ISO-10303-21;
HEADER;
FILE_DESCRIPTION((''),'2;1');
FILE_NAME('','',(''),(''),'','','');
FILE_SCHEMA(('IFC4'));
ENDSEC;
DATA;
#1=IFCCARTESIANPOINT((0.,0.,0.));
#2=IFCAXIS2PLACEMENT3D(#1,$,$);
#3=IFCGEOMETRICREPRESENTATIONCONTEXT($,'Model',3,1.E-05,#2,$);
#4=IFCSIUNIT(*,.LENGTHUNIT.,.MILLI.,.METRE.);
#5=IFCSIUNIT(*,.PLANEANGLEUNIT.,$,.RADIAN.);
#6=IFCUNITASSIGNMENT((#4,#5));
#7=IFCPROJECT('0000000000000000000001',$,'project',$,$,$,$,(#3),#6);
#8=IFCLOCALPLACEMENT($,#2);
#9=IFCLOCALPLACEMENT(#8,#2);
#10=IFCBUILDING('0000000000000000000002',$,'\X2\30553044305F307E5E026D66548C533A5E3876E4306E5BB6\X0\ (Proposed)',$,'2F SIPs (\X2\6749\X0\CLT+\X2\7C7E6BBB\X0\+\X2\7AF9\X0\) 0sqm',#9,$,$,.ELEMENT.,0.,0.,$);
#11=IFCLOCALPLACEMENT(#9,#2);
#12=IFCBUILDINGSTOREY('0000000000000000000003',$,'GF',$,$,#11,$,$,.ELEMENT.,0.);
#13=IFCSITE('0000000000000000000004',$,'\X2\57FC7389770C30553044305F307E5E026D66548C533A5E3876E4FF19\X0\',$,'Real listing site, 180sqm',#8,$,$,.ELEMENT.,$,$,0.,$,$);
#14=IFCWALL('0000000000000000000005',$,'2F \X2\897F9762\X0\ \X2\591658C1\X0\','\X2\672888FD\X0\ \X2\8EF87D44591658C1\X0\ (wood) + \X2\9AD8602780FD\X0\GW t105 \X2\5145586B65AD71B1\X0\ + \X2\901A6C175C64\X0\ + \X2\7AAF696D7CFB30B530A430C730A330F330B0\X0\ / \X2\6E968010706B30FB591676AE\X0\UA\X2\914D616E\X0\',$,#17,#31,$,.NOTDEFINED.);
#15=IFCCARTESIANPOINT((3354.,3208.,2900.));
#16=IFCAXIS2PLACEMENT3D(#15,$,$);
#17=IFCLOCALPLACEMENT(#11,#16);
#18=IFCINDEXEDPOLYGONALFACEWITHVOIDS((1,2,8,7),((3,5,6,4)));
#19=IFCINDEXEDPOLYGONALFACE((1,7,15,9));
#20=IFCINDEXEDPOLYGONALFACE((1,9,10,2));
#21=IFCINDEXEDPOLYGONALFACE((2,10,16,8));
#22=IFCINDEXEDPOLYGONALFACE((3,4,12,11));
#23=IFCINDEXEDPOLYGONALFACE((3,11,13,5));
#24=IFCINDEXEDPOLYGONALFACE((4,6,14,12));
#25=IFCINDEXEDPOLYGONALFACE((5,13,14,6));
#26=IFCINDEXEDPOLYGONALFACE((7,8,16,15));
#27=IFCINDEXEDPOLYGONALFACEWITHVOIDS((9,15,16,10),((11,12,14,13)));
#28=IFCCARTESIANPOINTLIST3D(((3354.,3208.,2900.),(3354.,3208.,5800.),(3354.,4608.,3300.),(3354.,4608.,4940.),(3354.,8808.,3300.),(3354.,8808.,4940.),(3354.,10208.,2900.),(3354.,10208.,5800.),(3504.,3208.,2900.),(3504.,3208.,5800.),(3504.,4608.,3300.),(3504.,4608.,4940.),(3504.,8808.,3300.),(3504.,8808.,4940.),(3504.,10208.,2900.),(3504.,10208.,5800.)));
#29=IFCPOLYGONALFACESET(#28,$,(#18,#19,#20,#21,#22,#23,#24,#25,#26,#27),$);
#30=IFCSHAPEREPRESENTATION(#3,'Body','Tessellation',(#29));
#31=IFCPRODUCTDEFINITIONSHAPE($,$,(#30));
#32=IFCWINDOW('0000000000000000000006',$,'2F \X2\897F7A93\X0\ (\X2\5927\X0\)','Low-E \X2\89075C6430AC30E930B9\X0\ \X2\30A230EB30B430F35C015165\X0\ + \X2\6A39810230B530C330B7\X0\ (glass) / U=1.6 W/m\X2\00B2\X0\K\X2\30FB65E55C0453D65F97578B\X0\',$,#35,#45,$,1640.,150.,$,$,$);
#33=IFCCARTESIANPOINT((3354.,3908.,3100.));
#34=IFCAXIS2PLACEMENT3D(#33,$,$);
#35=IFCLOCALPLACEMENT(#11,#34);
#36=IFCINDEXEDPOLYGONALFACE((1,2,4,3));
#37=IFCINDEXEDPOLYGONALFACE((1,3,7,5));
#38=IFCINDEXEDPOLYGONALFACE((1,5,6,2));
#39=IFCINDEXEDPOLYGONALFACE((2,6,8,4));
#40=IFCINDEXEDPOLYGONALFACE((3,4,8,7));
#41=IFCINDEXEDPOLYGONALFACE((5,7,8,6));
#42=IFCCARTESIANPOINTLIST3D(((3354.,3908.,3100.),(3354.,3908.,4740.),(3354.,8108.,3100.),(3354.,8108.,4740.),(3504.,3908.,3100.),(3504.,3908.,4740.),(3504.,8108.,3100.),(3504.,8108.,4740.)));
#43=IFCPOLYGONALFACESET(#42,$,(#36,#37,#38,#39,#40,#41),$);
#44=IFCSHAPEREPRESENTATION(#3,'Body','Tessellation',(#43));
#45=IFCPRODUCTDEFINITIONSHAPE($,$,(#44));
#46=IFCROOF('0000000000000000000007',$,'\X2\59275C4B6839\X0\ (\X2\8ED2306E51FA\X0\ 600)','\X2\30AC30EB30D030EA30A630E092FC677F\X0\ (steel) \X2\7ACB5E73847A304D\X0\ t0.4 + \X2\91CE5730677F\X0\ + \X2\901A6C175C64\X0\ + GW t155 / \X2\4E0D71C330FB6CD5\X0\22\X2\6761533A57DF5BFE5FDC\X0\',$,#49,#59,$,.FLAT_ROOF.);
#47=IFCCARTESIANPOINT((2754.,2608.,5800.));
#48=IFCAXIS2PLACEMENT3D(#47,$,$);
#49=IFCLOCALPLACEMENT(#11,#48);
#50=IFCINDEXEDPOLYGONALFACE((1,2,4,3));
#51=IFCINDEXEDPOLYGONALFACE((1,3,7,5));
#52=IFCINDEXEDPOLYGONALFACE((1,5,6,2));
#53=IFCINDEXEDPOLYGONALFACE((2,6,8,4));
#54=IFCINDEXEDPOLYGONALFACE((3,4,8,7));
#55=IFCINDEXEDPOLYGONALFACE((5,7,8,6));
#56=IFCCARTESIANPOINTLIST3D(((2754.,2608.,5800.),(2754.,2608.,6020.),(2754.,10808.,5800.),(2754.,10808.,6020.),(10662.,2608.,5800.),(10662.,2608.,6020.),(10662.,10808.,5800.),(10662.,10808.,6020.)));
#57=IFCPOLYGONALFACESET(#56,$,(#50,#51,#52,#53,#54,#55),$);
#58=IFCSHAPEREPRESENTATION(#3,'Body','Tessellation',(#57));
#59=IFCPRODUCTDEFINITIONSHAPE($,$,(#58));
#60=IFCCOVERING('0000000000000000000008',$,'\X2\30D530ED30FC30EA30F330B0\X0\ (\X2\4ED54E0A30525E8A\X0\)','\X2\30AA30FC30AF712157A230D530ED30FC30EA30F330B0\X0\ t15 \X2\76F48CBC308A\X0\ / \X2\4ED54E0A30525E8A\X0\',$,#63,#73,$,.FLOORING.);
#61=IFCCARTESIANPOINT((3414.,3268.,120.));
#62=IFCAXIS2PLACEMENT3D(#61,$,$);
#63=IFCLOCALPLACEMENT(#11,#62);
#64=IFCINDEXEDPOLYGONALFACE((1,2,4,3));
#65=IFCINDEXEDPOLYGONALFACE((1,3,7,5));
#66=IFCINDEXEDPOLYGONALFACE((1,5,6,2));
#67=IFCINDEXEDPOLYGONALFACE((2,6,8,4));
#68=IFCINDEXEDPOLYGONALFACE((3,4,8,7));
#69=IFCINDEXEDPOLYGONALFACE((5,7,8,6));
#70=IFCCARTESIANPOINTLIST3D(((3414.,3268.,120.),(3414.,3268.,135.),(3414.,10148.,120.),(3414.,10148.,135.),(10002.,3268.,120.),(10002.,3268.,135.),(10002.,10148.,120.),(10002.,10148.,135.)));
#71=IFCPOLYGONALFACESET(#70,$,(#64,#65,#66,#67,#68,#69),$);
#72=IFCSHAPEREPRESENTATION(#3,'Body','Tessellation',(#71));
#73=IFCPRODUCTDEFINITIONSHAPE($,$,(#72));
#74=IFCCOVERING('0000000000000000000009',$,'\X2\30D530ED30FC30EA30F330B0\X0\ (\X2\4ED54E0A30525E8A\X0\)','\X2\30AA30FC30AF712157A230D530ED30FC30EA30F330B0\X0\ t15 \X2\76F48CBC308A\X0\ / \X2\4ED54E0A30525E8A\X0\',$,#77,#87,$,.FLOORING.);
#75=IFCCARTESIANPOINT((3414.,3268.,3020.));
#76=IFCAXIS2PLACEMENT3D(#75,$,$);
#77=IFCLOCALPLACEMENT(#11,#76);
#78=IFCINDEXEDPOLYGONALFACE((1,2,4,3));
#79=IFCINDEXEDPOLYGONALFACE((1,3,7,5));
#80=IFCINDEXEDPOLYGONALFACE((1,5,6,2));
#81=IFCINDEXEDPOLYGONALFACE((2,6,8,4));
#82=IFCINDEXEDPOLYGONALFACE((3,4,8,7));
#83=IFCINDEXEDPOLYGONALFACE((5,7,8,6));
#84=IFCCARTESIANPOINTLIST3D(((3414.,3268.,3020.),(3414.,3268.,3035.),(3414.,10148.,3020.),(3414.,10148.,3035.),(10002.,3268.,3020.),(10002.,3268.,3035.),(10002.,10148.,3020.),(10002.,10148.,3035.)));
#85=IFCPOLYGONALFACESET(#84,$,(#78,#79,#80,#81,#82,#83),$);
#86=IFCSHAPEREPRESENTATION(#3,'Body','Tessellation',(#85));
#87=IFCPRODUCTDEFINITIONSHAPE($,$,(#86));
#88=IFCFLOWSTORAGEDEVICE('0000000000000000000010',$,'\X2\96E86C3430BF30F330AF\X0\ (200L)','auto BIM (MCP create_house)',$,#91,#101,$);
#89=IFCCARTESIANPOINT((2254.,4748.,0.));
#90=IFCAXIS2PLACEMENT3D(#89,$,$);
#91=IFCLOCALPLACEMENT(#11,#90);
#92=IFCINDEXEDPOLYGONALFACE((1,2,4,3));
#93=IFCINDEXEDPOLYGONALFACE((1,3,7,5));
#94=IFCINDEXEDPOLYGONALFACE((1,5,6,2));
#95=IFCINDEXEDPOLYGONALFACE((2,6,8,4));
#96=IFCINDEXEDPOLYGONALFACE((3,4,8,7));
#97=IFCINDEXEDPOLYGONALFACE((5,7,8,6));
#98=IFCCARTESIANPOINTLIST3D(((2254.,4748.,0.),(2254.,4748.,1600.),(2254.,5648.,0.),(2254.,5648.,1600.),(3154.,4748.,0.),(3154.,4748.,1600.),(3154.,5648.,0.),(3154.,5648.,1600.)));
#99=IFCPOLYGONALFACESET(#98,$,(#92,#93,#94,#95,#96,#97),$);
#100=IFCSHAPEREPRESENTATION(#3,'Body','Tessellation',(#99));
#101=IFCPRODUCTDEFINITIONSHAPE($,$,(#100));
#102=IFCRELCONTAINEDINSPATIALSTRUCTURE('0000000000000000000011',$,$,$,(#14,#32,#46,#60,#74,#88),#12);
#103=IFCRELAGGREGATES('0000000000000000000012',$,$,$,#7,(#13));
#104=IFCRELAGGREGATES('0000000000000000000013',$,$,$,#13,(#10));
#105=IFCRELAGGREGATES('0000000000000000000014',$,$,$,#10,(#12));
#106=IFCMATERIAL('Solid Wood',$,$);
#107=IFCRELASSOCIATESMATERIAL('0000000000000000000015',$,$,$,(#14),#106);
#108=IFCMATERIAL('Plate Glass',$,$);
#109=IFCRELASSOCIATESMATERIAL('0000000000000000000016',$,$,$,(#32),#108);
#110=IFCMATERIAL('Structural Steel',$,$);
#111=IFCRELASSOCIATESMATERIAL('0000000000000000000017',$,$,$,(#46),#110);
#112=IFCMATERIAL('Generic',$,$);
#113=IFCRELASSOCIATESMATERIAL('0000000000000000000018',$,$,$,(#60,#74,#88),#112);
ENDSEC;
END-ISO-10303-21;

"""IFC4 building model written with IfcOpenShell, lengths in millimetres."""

from ifc_helpers import new_model, si_unit, frame, frame_2d, origin, place, context, project, spatial, rectangle, extrude, material, element, fill, save


model = new_model("IFC4")

# Units and contexts
model_context = context("Model", 3, precision=1e-05, world=origin())
ifc_project = project(units=[si_unit("LENGTHUNIT", "METRE", prefix="MILLI"), si_unit("PLANEANGLEUNIT", "RADIAN")], contexts=[model_context])

# Site, building, storey
site_placement = place(None, origin())
site = spatial("IfcSite", under=ifc_project, at=site_placement, Name="埼玉県さいたま市浦和区常盤９", ObjectType="Real listing site, 180sqm", CompositionType="ELEMENT", RefElevation=0.0)
building_placement = place(site_placement, origin())
building = spatial("IfcBuilding", under=site, at=building_placement, Name="さいたま市浦和区常盤の家 (Proposed)", ObjectType="2F SIPs (杉CLT+籾殻+竹) 0sqm", CompositionType="ELEMENT", ElevationOfRefHeight=0.0, ElevationOfTerrain=0.0)
storey_placement = place(building_placement, origin())
storey = spatial("IfcBuildingStorey", under=building, at=storey_placement, Name="GF", CompositionType="ELEMENT", Elevation=0.0)

# Shared definitions
ifc_material_1 = material(Name="Solid Wood")

# Shared definitions
ifc_material_2 = material(Name="Plate Glass")

# Wall, opening, window
wall_1_placement = place(storey_placement, frame((3354.0, 3208.0, 2900.0)))
wall_1 = element("IfcWall", 1, at=wall_1_placement, inside=storey, material=ifc_material_1, Name="2F 西面 外壁", Description="木製 軸組外壁 (wood) + 高性能GW t105 充填断熱 + 通気層 + 窯業系サイディング / 準耐火・外皮UA配慮", PredefinedType="NOTDEFINED", context=model_context, shape_type="SweptSolid", body=[
    extrude(rectangle(XDim=150.0, YDim=7000.0, at=frame_2d((75.0, 3500.0))), frame((3354.0, 3208.0, 2900.0)), (0.0, 0.0, 1.0), 2900.0),
])
opening_1_placement = place(storey_placement, frame((3354.0, 3908.0, 3100.0)))
opening_1 = element("IfcOpeningElement", 2, at=opening_1_placement, cuts=wall_1, PredefinedType="NOTDEFINED", context=model_context, shape_type="SweptSolid", body=[
    extrude(rectangle(XDim=150.0, YDim=4200.0, at=frame_2d((75.0, 2100.0))), frame((3354.0, 3908.0, 3100.0)), (0.0, 0.0, 1.0), 1640.0),
])
window_1_placement = place(storey_placement, frame((3354.0, 3908.0, 3100.0)))
window_1 = element("IfcWindow", 3, at=window_1_placement, inside=storey, material=ifc_material_2, Name="2F 西窓 (大)", Description="Low-E 複層ガラス アルゴン封入 + 樹脂サッシ (glass) / U=1.6 W/m²K・日射取得型", OverallHeight=1640.0, OverallWidth=150.0, context=model_context, shape_type="SweptSolid", body=[
    extrude(rectangle(XDim=150.0, YDim=4200.0, at=frame_2d((75.0, 2100.0))), frame((3354.0, 3908.0, 3100.0)), (0.0, 0.0, 1.0), 1640.0),
])
fill(opening_1, window_1)

# Roof
ifc_material_3 = material(Name="Structural Steel")
roof_placement = place(storey_placement, frame((2754.0, 2608.0, 5800.0)))
element("IfcRoof", 4, at=roof_placement, inside=storey, material=ifc_material_3, Name="大屋根 (軒の出 600)", Description="ガルバリウム鋼板 (steel) 立平葺き t0.4 + 野地板 + 通気層 + GW t155 / 不燃・法22条区域対応", PredefinedType="FLAT_ROOF", context=model_context, shape_type="SweptSolid", body=[
    extrude(rectangle(XDim=7908.0, YDim=8200.0, at=frame_2d((3954.0, 4100.0))), frame((2754.0, 2608.0, 5800.0)), (0.0, 0.0, 1.0), 220.0),
])

# Coverings
ifc_material_4 = material(Name="Generic")
covering_1_placement = place(storey_placement, frame((3414.0, 3268.0, 120.0)))
element("IfcCovering", 5, at=covering_1_placement, inside=storey, material=ifc_material_4, Name="フローリング (仕上げ床)", Description="オーク無垢フローリング t15 直貼り / 仕上げ床", PredefinedType="FLOORING", context=model_context, shape_type="SweptSolid", body=[
    extrude(rectangle(XDim=6588.0, YDim=6880.0, at=frame_2d((3294.0, 3440.0))), frame((3414.0, 3268.0, 120.0)), (0.0, 0.0, 1.0), 15.0),
])
covering_2_placement = place(storey_placement, frame((3414.0, 3268.0, 3020.0)))
element("IfcCovering", 6, at=covering_2_placement, inside=storey, material=ifc_material_4, Name="フローリング (仕上げ床)", Description="オーク無垢フローリング t15 直貼り / 仕上げ床", PredefinedType="FLOORING", context=model_context, shape_type="SweptSolid", body=[
    extrude(rectangle(XDim=6588.0, YDim=6880.0, at=frame_2d((3294.0, 3440.0))), frame((3414.0, 3268.0, 3020.0)), (0.0, 0.0, 1.0), 15.0),
])

# Flow storage device
flow_storage_device_placement = place(storey_placement, frame((2254.0, 4748.0, 0.0)))
element("IfcFlowStorageDevice", 7, at=flow_storage_device_placement, inside=storey, material=ifc_material_4, Name="雨水タンク (200L)", Description="auto BIM (MCP create_house)", context=model_context, shape_type="SweptSolid", body=[
    extrude(rectangle(XDim=900.0, YDim=900.0, at=frame_2d((450.0, 450.0))), frame((2254.0, 4748.0, 0.0)), (0.0, 0.0, 1.0), 1600.0),
])

save(model, "model.ifc")
